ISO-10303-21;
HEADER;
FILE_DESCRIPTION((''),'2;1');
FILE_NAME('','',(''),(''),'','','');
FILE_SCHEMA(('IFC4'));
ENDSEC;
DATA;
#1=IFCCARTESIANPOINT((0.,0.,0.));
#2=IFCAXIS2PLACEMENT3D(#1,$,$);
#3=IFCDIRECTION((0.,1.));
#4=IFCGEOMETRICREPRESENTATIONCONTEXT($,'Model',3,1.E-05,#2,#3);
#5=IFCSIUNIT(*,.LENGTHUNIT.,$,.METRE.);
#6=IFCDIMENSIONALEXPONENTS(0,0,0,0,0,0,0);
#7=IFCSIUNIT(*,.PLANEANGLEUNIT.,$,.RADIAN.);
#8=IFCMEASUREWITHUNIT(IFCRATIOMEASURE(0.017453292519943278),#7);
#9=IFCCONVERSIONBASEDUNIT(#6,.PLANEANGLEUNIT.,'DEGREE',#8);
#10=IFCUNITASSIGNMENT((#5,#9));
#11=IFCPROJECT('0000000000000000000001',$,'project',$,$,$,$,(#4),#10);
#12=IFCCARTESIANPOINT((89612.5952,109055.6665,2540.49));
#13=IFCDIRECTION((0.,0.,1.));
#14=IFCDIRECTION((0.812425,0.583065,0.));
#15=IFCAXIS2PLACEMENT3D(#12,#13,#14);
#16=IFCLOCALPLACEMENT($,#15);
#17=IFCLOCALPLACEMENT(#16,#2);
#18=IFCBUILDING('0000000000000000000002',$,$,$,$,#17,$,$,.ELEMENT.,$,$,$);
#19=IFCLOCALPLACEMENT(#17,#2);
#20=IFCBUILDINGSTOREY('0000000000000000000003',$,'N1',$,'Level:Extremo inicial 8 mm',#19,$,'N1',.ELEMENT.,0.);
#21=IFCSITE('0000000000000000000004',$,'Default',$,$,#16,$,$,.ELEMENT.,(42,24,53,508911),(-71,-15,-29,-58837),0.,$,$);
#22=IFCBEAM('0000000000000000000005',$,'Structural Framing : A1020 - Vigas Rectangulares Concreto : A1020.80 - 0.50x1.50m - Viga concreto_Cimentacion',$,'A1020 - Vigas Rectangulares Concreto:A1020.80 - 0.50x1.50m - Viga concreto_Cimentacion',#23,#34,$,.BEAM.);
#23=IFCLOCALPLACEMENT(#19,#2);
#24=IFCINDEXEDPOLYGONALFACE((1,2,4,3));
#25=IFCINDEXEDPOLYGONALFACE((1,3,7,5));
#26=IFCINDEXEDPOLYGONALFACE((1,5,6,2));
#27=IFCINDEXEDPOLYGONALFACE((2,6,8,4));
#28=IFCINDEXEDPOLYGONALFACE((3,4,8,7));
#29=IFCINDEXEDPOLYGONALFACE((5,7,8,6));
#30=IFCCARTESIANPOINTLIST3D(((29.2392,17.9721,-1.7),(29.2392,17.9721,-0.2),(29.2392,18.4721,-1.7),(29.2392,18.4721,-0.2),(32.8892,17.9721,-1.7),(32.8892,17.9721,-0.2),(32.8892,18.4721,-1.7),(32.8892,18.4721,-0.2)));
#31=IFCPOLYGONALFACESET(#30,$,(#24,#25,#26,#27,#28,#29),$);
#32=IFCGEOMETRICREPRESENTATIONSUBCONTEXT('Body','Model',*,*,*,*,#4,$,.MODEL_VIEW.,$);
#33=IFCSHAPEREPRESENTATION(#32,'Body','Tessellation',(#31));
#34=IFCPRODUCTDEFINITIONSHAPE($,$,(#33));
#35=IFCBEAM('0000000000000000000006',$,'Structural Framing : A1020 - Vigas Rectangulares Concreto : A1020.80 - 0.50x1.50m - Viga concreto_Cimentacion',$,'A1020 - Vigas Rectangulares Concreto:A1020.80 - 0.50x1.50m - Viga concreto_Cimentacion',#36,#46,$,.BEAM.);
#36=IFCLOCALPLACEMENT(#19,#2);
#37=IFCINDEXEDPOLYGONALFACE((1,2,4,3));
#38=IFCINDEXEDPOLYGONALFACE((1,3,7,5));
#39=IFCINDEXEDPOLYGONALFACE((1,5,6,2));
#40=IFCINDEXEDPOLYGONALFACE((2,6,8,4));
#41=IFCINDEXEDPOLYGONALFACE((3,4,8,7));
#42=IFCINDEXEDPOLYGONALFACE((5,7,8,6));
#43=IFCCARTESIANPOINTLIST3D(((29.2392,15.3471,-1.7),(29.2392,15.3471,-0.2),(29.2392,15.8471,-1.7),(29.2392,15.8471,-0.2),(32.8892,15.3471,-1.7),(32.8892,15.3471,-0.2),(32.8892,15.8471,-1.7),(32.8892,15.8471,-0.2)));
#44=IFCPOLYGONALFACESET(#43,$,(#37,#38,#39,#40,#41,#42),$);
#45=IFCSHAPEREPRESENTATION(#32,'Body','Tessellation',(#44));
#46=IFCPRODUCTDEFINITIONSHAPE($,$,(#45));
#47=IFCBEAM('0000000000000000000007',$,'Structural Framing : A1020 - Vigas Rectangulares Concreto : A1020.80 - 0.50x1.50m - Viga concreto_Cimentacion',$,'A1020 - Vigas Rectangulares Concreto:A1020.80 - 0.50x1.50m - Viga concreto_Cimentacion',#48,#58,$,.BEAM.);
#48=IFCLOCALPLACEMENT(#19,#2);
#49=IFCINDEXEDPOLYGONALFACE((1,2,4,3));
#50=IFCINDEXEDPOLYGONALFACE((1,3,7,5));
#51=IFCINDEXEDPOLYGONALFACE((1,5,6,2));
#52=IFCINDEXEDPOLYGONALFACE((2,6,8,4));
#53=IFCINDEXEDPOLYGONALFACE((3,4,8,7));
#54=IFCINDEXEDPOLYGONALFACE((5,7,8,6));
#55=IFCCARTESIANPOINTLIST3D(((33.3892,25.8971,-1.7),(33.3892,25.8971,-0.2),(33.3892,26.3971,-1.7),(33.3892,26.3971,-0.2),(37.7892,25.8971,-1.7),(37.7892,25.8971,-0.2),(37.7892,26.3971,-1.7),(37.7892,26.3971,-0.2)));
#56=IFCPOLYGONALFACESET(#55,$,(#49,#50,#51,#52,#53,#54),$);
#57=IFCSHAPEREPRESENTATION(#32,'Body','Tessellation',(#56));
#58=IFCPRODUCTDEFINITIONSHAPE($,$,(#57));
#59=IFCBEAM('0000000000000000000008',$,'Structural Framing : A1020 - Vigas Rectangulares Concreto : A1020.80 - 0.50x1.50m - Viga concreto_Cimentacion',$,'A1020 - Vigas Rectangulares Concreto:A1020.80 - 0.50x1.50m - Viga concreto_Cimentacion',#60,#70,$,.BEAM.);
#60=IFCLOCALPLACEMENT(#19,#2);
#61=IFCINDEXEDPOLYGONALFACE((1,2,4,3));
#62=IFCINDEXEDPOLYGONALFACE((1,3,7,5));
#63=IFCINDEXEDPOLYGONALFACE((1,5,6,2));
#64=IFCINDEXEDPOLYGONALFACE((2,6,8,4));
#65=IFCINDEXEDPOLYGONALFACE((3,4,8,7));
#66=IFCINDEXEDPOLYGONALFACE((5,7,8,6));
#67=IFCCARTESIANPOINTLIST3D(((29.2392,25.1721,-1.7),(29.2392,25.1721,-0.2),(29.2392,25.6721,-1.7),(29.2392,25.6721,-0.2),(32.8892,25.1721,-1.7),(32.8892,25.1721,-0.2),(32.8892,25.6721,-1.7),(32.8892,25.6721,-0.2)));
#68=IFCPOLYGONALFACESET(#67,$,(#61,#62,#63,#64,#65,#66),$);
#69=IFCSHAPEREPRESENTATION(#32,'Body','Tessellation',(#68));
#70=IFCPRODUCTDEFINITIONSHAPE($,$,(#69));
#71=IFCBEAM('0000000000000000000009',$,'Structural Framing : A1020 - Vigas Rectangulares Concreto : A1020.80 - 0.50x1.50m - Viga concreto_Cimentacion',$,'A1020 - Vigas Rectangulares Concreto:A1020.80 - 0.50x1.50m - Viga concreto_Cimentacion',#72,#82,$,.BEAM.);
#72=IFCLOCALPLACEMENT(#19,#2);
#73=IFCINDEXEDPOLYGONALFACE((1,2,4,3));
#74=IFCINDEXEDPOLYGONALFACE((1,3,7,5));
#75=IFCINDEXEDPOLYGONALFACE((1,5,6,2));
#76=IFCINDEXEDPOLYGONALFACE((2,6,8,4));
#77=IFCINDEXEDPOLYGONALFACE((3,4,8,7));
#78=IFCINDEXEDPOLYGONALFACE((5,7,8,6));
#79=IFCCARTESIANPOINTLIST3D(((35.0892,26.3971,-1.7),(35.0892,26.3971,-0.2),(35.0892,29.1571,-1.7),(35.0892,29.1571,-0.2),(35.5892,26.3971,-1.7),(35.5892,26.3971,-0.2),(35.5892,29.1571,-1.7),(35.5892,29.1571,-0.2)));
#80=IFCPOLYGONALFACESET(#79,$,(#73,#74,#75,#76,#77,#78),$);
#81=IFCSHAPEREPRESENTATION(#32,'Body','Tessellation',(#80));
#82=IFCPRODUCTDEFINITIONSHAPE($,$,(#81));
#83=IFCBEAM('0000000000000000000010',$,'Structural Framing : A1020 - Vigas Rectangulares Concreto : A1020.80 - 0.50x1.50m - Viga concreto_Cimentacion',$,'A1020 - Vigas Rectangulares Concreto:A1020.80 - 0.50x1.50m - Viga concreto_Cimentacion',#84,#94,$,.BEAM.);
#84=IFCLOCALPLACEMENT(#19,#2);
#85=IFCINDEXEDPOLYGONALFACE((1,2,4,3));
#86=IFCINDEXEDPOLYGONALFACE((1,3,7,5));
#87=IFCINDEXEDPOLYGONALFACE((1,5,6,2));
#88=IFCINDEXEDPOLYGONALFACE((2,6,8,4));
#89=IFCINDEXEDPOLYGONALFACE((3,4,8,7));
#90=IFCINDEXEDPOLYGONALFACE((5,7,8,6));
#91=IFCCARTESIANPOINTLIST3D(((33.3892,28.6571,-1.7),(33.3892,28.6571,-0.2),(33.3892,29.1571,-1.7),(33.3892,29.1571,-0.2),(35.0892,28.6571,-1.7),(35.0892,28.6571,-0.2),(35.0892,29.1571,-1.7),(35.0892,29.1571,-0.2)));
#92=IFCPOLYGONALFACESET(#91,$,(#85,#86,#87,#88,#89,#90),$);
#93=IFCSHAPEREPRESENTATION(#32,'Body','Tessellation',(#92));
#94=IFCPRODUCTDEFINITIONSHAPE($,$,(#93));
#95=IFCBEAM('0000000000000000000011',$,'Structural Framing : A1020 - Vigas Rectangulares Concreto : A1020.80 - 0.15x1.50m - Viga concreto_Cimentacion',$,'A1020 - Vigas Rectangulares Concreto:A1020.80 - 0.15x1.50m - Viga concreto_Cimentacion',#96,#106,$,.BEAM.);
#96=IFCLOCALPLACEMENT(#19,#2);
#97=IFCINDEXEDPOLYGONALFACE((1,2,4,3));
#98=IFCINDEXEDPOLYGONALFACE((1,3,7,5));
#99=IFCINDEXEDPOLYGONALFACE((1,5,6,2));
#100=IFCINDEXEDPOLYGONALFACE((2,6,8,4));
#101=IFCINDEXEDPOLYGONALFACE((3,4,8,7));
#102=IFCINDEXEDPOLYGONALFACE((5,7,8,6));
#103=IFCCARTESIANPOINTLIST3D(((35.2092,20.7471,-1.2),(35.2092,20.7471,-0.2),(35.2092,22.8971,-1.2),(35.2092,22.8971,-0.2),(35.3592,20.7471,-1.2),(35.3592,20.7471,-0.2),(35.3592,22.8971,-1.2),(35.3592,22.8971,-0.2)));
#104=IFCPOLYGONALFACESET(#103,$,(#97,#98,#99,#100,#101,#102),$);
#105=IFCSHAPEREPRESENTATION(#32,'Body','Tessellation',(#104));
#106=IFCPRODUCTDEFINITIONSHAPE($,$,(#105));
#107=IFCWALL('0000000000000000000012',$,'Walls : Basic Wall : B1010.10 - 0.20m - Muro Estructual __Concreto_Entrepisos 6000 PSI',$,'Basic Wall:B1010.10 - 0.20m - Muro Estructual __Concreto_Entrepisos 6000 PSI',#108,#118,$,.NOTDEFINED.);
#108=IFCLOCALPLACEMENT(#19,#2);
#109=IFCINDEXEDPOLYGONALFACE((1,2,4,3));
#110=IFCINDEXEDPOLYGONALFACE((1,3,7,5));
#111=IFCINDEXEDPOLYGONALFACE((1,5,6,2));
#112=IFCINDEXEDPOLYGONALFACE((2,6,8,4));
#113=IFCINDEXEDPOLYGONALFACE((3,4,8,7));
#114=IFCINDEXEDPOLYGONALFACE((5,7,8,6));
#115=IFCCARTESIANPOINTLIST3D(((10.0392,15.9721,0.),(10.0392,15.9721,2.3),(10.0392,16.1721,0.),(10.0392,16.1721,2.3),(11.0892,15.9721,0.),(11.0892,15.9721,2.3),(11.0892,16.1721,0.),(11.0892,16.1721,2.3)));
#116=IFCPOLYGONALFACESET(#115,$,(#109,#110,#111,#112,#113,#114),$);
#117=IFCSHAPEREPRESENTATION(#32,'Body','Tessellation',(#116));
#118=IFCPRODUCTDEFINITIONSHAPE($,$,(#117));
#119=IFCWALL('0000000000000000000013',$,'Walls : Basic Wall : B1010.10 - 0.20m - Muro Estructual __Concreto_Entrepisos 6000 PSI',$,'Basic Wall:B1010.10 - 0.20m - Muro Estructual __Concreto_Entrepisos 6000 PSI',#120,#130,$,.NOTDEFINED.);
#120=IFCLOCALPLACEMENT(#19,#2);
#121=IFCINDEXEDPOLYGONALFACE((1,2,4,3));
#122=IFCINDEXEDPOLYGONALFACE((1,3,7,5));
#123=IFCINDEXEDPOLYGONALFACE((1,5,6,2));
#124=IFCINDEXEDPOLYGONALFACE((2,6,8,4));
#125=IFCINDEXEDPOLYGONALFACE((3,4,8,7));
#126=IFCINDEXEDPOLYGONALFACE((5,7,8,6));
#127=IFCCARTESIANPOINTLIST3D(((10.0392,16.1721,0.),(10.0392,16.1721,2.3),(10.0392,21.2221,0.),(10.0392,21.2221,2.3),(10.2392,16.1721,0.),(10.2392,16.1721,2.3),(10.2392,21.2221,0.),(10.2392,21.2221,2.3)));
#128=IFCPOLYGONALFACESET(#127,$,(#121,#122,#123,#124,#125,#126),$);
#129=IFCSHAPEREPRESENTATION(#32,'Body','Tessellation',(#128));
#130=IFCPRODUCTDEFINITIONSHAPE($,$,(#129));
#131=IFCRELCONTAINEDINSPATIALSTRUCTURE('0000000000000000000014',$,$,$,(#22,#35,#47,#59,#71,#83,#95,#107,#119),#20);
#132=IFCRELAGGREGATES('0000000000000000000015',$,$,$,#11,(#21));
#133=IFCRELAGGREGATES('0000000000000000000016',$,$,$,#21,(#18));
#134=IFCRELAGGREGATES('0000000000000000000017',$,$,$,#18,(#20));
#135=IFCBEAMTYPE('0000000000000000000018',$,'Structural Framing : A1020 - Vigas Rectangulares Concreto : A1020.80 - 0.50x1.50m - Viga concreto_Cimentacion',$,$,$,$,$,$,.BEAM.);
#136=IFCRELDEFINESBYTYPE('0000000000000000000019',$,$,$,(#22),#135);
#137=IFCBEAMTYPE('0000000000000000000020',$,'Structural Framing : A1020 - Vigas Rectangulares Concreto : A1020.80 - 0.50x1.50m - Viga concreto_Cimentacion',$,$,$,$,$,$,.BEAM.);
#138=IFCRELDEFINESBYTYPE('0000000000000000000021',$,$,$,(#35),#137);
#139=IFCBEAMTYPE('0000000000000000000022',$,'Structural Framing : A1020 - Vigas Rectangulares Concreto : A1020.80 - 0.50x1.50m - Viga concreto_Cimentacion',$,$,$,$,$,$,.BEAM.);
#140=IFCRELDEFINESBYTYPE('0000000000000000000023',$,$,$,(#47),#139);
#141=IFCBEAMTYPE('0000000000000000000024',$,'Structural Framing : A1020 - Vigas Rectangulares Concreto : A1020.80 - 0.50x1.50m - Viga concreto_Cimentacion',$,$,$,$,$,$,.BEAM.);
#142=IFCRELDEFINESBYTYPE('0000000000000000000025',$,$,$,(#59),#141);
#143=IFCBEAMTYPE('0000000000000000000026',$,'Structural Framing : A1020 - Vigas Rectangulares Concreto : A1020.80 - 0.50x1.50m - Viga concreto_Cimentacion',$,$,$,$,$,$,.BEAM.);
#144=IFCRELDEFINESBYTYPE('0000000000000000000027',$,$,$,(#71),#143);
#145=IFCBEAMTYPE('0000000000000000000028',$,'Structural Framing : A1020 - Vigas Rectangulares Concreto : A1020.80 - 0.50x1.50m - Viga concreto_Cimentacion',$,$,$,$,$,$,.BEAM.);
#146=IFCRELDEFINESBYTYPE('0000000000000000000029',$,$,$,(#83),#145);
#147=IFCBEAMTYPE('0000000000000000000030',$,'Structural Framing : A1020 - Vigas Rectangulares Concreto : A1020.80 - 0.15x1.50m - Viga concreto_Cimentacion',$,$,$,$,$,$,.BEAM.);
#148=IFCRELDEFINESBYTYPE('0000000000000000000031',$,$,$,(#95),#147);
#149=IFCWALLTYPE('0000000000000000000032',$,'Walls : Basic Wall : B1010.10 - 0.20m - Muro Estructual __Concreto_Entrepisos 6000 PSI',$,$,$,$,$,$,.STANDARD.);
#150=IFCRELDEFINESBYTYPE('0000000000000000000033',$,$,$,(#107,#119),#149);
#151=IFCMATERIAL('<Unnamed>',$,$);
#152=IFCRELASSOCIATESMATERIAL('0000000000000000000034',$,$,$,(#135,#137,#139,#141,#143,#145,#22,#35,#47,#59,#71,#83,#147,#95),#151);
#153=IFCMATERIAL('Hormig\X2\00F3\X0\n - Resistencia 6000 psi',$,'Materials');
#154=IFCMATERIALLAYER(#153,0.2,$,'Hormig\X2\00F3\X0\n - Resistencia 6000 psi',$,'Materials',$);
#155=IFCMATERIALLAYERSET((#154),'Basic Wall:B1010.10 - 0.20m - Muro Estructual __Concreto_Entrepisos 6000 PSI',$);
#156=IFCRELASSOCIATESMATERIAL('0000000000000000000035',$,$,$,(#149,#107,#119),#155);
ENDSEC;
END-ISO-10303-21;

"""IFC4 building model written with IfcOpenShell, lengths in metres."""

from ifc_helpers import new_model, entity, si_unit, converted_unit, direction, frame, frame_2d, origin, place, context, subcontext, project, spatial, polyline, segment, composite_curve, rectangle, outline, extrude, source, transform, mapped, material, layer, layer_set, layer_usage, material_profile, profile_set, profile_usage, type_object, type_shapes, element, save


model = new_model("IFC4")

# Units and contexts
model_context = context("Model", 3, precision=1e-05, world=origin(), true_north=direction((0.0, 1.0)))
body_context = subcontext(model_context, "Body", "Model", "MODEL_VIEW")
ifc_project = project(units=[si_unit("LENGTHUNIT", "METRE"), converted_unit("PLANEANGLEUNIT", "DEGREE", entity("IfcRatioMeasure", 0.017453292519943278), si_unit("PLANEANGLEUNIT", "RADIAN"), dimensions=[0, 0, 0, 0, 0, 0, 0])], contexts=[model_context])

# Site, building, storey
site_placement = place(None, frame((89612.5952, 109055.6665, 2540.49), z_axis=(0.0, 0.0, 1.0), x_axis=(0.812425, 0.583065, 0.0)))
site = spatial("IfcSite", under=ifc_project, at=site_placement, Name="Default", CompositionType="ELEMENT", RefLatitude=(42, 24, 53, 508911), RefLongitude=(-71, -15, -29, -58837), RefElevation=0.0)
building_placement = place(site_placement, origin())
building = spatial("IfcBuilding", under=site, at=building_placement, CompositionType="ELEMENT")
storey_placement = place(building_placement, origin())
storey = spatial("IfcBuildingStorey", under=building, at=storey_placement, Name="N1", ObjectType="Level:Extremo inicial 8 mm", LongName="N1", CompositionType="ELEMENT", Elevation=0.0)

# Beams
ifc_material_1 = material(Name="<Unnamed>")
ifc_material_profile_1 = material_profile(ifc_material_1, outline(composite_curve([segment(polyline([(-0.25, -0.75, 0.0), (-0.25, 0.75, 0.0)]), True, "CONTINUOUS"), segment(polyline([(-0.25, 0.75, 0.0), (0.25, 0.75, 0.0)]), True, "CONTINUOUS"), segment(polyline([(0.25, 0.75, 0.0), (0.25, -0.75, 0.0)]), True, "CONTINUOUS"), segment(polyline([(0.25, -0.75, 0.0), (-0.25, -0.75, 0.0)]), True, "CONTINUOUS")], self_intersect=False), kind="CURVE"), Name="A1020.80 - 0.50x1.50m - Viga concreto_Cimentacion")
ifc_material_profile_2 = material_profile(ifc_material_1, outline(composite_curve([segment(polyline([(6.1973, 0.25, 0.75), (6.1973, 0.25, -0.75)]), True, "CONTINUOUS"), segment(polyline([(6.1973, 0.25, -0.75), (-6.1973, 0.25, -0.75)]), True, "CONTINUOUS"), segment(polyline([(-6.1973, 0.25, -0.75), (-6.1973, 0.25, 0.75)]), True, "CONTINUOUS"), segment(polyline([(-6.1973, 0.25, 0.75), (6.1973, 0.25, 0.75)]), True, "CONTINUOUS")], self_intersect=False), kind="CURVE"), Name="A1020.80 - 0.50x1.50m - Viga concreto_Cimentacion")
ifc_profile_set_1 = profile_set([ifc_material_profile_1, ifc_material_profile_2], Name="A1020.80 - 0.50x1.50m - Viga concreto_Cimentacion")
ifc_profile_usage_1 = profile_usage(ifc_profile_set_1, cardinal=8)
beam_type_1 = type_object("IfcBeamType", Name="Structural Framing : A1020 - Vigas Rectangulares Concreto : A1020.80 - 0.50x1.50m - Viga concreto_Cimentacion", PredefinedType="BEAM", material=ifc_profile_set_1)
shared_shape_1 = source(origin(), body_context, "Body", "SweptSolid", [
    extrude(rectangle(XDim=1.5, YDim=0.5, at=frame_2d((0.0, 0.0), x_axis=(1.0, 0.0))), frame((29.2392, 18.2221, -0.95), z_axis=(1.0, 0.0, 0.0), x_axis=(0.0, 0.0, -1.0)), (0.0, 0.0, 1.0), 3.65),
])
type_shapes(beam_type_1, [shared_shape_1])
beam_1_placement = place(storey_placement, origin())
element("IfcBeam", 1, at=beam_1_placement, inside=storey, type_object=beam_type_1, material=ifc_profile_usage_1, Name="Structural Framing : A1020 - Vigas Rectangulares Concreto : A1020.80 - 0.50x1.50m - Viga concreto_Cimentacion", ObjectType="A1020 - Vigas Rectangulares Concreto:A1020.80 - 0.50x1.50m - Viga concreto_Cimentacion", PredefinedType="BEAM", context=body_context, shape_type="MappedRepresentation", body=[
    mapped(shared_shape_1, transform((0.0, 0.0, 0.0), scale=1.0)),
])
ifc_profile_usage_2 = profile_usage(ifc_profile_set_1, cardinal=8)
beam_type_2 = type_object("IfcBeamType", Name="Structural Framing : A1020 - Vigas Rectangulares Concreto : A1020.80 - 0.50x1.50m - Viga concreto_Cimentacion", PredefinedType="BEAM", material=ifc_profile_set_1)
shared_shape_2 = source(origin(), body_context, "Body", "SweptSolid", [
    extrude(rectangle(XDim=1.5, YDim=0.5, at=frame_2d((0.0, 0.0), x_axis=(1.0, 0.0))), frame((29.2392, 15.5971, -0.95), z_axis=(1.0, 0.0, 0.0), x_axis=(0.0, 0.0, -1.0)), (0.0, 0.0, 1.0), 3.65),
])
type_shapes(beam_type_2, [shared_shape_2])
beam_2_placement = place(storey_placement, origin())
element("IfcBeam", 2, at=beam_2_placement, inside=storey, type_object=beam_type_2, material=ifc_profile_usage_2, Name="Structural Framing : A1020 - Vigas Rectangulares Concreto : A1020.80 - 0.50x1.50m - Viga concreto_Cimentacion", ObjectType="A1020 - Vigas Rectangulares Concreto:A1020.80 - 0.50x1.50m - Viga concreto_Cimentacion", PredefinedType="BEAM", context=body_context, shape_type="MappedRepresentation", body=[
    mapped(shared_shape_2, transform((0.0, 0.0, 0.0), scale=1.0)),
])
ifc_profile_usage_3 = profile_usage(ifc_profile_set_1, cardinal=8)
beam_type_3 = type_object("IfcBeamType", Name="Structural Framing : A1020 - Vigas Rectangulares Concreto : A1020.80 - 0.50x1.50m - Viga concreto_Cimentacion", PredefinedType="BEAM", material=ifc_profile_set_1)
shared_shape_3 = source(origin(), body_context, "Body", "SweptSolid", [
    extrude(rectangle(XDim=1.5, YDim=0.5, at=frame_2d((0.0, 0.0), x_axis=(1.0, 0.0))), frame((37.7892, 26.1471, -0.95), z_axis=(-1.0, 0.0, 0.0), x_axis=(0.0, 0.0, -1.0)), (0.0, 0.0, 1.0), 4.4),
])
type_shapes(beam_type_3, [shared_shape_3])
beam_3_placement = place(storey_placement, origin())
element("IfcBeam", 3, at=beam_3_placement, inside=storey, type_object=beam_type_3, material=ifc_profile_usage_3, Name="Structural Framing : A1020 - Vigas Rectangulares Concreto : A1020.80 - 0.50x1.50m - Viga concreto_Cimentacion", ObjectType="A1020 - Vigas Rectangulares Concreto:A1020.80 - 0.50x1.50m - Viga concreto_Cimentacion", PredefinedType="BEAM", context=body_context, shape_type="MappedRepresentation", body=[
    mapped(shared_shape_3, transform((0.0, 0.0, 0.0), scale=1.0)),
])
ifc_profile_usage_4 = profile_usage(ifc_profile_set_1, cardinal=8)
beam_type_4 = type_object("IfcBeamType", Name="Structural Framing : A1020 - Vigas Rectangulares Concreto : A1020.80 - 0.50x1.50m - Viga concreto_Cimentacion", PredefinedType="BEAM", material=ifc_profile_set_1)
shared_shape_4 = source(origin(), body_context, "Body", "SweptSolid", [
    extrude(rectangle(XDim=1.5, YDim=0.5, at=frame_2d((0.0, 0.0), x_axis=(1.0, 0.0))), frame((29.2392, 25.4221, -0.95), z_axis=(1.0, 0.0, 0.0), x_axis=(0.0, 0.0, -1.0)), (0.0, 0.0, 1.0), 3.65),
])
type_shapes(beam_type_4, [shared_shape_4])
beam_4_placement = place(storey_placement, origin())
element("IfcBeam", 4, at=beam_4_placement, inside=storey, type_object=beam_type_4, material=ifc_profile_usage_4, Name="Structural Framing : A1020 - Vigas Rectangulares Concreto : A1020.80 - 0.50x1.50m - Viga concreto_Cimentacion", ObjectType="A1020 - Vigas Rectangulares Concreto:A1020.80 - 0.50x1.50m - Viga concreto_Cimentacion", PredefinedType="BEAM", context=body_context, shape_type="MappedRepresentation", body=[
    mapped(shared_shape_4, transform((0.0, 0.0, 0.0), scale=1.0)),
])
ifc_profile_usage_5 = profile_usage(ifc_profile_set_1, cardinal=8)
beam_type_5 = type_object("IfcBeamType", Name="Structural Framing : A1020 - Vigas Rectangulares Concreto : A1020.80 - 0.50x1.50m - Viga concreto_Cimentacion", PredefinedType="BEAM", material=ifc_profile_set_1)
shared_shape_5 = source(origin(), body_context, "Body", "SweptSolid", [
    extrude(rectangle(XDim=1.5, YDim=0.5, at=frame_2d((0.0, 0.0), x_axis=(0.0, 1.0))), frame((35.3392, 26.3971, -0.95), z_axis=(0.0, 1.0, 0.0), x_axis=(-1.0, 0.0, 0.0)), (0.0, 0.0, 1.0), 2.76),
])
type_shapes(beam_type_5, [shared_shape_5])
beam_5_placement = place(storey_placement, origin())
element("IfcBeam", 5, at=beam_5_placement, inside=storey, type_object=beam_type_5, material=ifc_profile_usage_5, Name="Structural Framing : A1020 - Vigas Rectangulares Concreto : A1020.80 - 0.50x1.50m - Viga concreto_Cimentacion", ObjectType="A1020 - Vigas Rectangulares Concreto:A1020.80 - 0.50x1.50m - Viga concreto_Cimentacion", PredefinedType="BEAM", context=body_context, shape_type="MappedRepresentation", body=[
    mapped(shared_shape_5, transform((0.0, 0.0, 0.0), scale=1.0)),
])
ifc_profile_usage_6 = profile_usage(ifc_profile_set_1, cardinal=8)
beam_type_6 = type_object("IfcBeamType", Name="Structural Framing : A1020 - Vigas Rectangulares Concreto : A1020.80 - 0.50x1.50m - Viga concreto_Cimentacion", PredefinedType="BEAM", material=ifc_profile_set_1)
shared_shape_6 = source(origin(), body_context, "Body", "SweptSolid", [
    extrude(rectangle(XDim=1.5, YDim=0.5, at=frame_2d((0.0, 0.0), x_axis=(1.0, 0.0))), frame((33.3892, 28.9071, -0.95), z_axis=(1.0, 0.0, 0.0), x_axis=(0.0, 0.0, -1.0)), (0.0, 0.0, 1.0), 1.7),
])
type_shapes(beam_type_6, [shared_shape_6])
beam_6_placement = place(storey_placement, origin())
element("IfcBeam", 6, at=beam_6_placement, inside=storey, type_object=beam_type_6, material=ifc_profile_usage_6, Name="Structural Framing : A1020 - Vigas Rectangulares Concreto : A1020.80 - 0.50x1.50m - Viga concreto_Cimentacion", ObjectType="A1020 - Vigas Rectangulares Concreto:A1020.80 - 0.50x1.50m - Viga concreto_Cimentacion", PredefinedType="BEAM", context=body_context, shape_type="MappedRepresentation", body=[
    mapped(shared_shape_6, transform((0.0, 0.0, 0.0), scale=1.0)),
])
ifc_material_profile_3 = material_profile(ifc_material_1, outline(composite_curve([segment(polyline([(-0.075, -0.5, 0.0), (-0.075, 0.5, 0.0)]), True, "CONTINUOUS"), segment(polyline([(-0.075, 0.5, 0.0), (0.075, 0.5, 0.0)]), True, "CONTINUOUS"), segment(polyline([(0.075, 0.5, 0.0), (0.075, -0.5, 0.0)]), True, "CONTINUOUS"), segment(polyline([(0.075, -0.5, 0.0), (-0.075, -0.5, 0.0)]), True, "CONTINUOUS")], self_intersect=False), kind="CURVE"), Name="A1020.80 - 0.15x1.50m - Viga concreto_Cimentacion")
ifc_material_profile_4 = material_profile(ifc_material_1, outline(composite_curve([segment(polyline([(1.2123, -0.075, -0.5), (1.2123, -0.075, 0.5)]), True, "CONTINUOUS"), segment(polyline([(1.2123, -0.075, 0.5), (-1.2123, -0.075, 0.5)]), True, "CONTINUOUS"), segment(polyline([(-1.2123, -0.075, 0.5), (-1.2123, -0.075, -0.5)]), True, "CONTINUOUS"), segment(polyline([(-1.2123, -0.075, -0.5), (1.2123, -0.075, -0.5)]), True, "CONTINUOUS")], self_intersect=False), kind="CURVE"), Name="A1020.80 - 0.15x1.50m - Viga concreto_Cimentacion")
ifc_profile_set_2 = profile_set([ifc_material_profile_3, ifc_material_profile_4], Name="A1020.80 - 0.15x1.50m - Viga concreto_Cimentacion")
ifc_profile_usage_7 = profile_usage(ifc_profile_set_2, cardinal=8)
beam_type_7 = type_object("IfcBeamType", Name="Structural Framing : A1020 - Vigas Rectangulares Concreto : A1020.80 - 0.15x1.50m - Viga concreto_Cimentacion", PredefinedType="BEAM", material=ifc_profile_set_2)
shared_shape_7 = source(origin(), body_context, "Body", "SweptSolid", [
    extrude(rectangle(XDim=1.0, YDim=0.15, at=frame_2d((0.0, 0.0), x_axis=(0.0, 1.0))), frame((35.2842, 20.7471, -0.7), z_axis=(0.0, 1.0, 0.0), x_axis=(-1.0, 0.0, 0.0)), (0.0, 0.0, 1.0), 2.15),
])
type_shapes(beam_type_7, [shared_shape_7])
beam_7_placement = place(storey_placement, origin())
element("IfcBeam", 7, at=beam_7_placement, inside=storey, type_object=beam_type_7, material=ifc_profile_usage_7, Name="Structural Framing : A1020 - Vigas Rectangulares Concreto : A1020.80 - 0.15x1.50m - Viga concreto_Cimentacion", ObjectType="A1020 - Vigas Rectangulares Concreto:A1020.80 - 0.15x1.50m - Viga concreto_Cimentacion", PredefinedType="BEAM", context=body_context, shape_type="MappedRepresentation", body=[
    mapped(shared_shape_7, transform((0.0, 0.0, 0.0), scale=1.0)),
])

# Walls
ifc_material_2 = material(Name="Hormigón - Resistencia 6000 psi", Category="Materials")
ifc_layer_1 = layer(ifc_material_2, 0.2, Name="Hormigón - Resistencia 6000 psi", Category="Materials")
ifc_layer_set_1 = layer_set([ifc_layer_1], Name="Basic Wall:B1010.10 - 0.20m - Muro Estructual __Concreto_Entrepisos 6000 PSI")
ifc_layer_usage_1 = layer_usage(ifc_layer_set_1, "AXIS2", "NEGATIVE", 0.1)
wall_type = type_object("IfcWallType", Name="Walls : Basic Wall : B1010.10 - 0.20m - Muro Estructual __Concreto_Entrepisos 6000 PSI", PredefinedType="STANDARD", material=ifc_layer_set_1)
wall_1_placement = place(storey_placement, frame((11.0892, 16.0721, 0.0), z_axis=(0.0, 0.0, 1.0), x_axis=(-1.0, 0.0, 0.0)))
element("IfcWall", 8, at=wall_1_placement, inside=storey, type_object=wall_type, material=ifc_layer_usage_1, Name="Walls : Basic Wall : B1010.10 - 0.20m - Muro Estructual __Concreto_Entrepisos 6000 PSI", ObjectType="Basic Wall:B1010.10 - 0.20m - Muro Estructual __Concreto_Entrepisos 6000 PSI", PredefinedType="NOTDEFINED", context=body_context, shape_type="SweptSolid", body=[
    extrude(rectangle(XDim=1.05, YDim=0.2, at=frame_2d((0.525, 0.0), x_axis=(-1.0, 0.0))), origin(), (0.0, 0.0, 1.0), 2.3),
])
ifc_layer_usage_2 = layer_usage(ifc_layer_set_1, "AXIS2", "NEGATIVE", 0.1)
wall_2_placement = place(storey_placement, frame((10.1392, 16.1721, 0.0), z_axis=(0.0, 0.0, 1.0), x_axis=(0.0, 1.0, 0.0)))
element("IfcWall", 9, at=wall_2_placement, inside=storey, type_object=wall_type, material=ifc_layer_usage_2, Name="Walls : Basic Wall : B1010.10 - 0.20m - Muro Estructual __Concreto_Entrepisos 6000 PSI", ObjectType="Basic Wall:B1010.10 - 0.20m - Muro Estructual __Concreto_Entrepisos 6000 PSI", PredefinedType="NOTDEFINED", context=body_context, shape_type="SweptSolid", body=[
    extrude(rectangle(XDim=5.05, YDim=0.2, at=frame_2d((2.525, 0.0), x_axis=(-1.0, 0.0))), origin(), (0.0, 0.0, 1.0), 2.3),
])

save(model, "model.ifc")
